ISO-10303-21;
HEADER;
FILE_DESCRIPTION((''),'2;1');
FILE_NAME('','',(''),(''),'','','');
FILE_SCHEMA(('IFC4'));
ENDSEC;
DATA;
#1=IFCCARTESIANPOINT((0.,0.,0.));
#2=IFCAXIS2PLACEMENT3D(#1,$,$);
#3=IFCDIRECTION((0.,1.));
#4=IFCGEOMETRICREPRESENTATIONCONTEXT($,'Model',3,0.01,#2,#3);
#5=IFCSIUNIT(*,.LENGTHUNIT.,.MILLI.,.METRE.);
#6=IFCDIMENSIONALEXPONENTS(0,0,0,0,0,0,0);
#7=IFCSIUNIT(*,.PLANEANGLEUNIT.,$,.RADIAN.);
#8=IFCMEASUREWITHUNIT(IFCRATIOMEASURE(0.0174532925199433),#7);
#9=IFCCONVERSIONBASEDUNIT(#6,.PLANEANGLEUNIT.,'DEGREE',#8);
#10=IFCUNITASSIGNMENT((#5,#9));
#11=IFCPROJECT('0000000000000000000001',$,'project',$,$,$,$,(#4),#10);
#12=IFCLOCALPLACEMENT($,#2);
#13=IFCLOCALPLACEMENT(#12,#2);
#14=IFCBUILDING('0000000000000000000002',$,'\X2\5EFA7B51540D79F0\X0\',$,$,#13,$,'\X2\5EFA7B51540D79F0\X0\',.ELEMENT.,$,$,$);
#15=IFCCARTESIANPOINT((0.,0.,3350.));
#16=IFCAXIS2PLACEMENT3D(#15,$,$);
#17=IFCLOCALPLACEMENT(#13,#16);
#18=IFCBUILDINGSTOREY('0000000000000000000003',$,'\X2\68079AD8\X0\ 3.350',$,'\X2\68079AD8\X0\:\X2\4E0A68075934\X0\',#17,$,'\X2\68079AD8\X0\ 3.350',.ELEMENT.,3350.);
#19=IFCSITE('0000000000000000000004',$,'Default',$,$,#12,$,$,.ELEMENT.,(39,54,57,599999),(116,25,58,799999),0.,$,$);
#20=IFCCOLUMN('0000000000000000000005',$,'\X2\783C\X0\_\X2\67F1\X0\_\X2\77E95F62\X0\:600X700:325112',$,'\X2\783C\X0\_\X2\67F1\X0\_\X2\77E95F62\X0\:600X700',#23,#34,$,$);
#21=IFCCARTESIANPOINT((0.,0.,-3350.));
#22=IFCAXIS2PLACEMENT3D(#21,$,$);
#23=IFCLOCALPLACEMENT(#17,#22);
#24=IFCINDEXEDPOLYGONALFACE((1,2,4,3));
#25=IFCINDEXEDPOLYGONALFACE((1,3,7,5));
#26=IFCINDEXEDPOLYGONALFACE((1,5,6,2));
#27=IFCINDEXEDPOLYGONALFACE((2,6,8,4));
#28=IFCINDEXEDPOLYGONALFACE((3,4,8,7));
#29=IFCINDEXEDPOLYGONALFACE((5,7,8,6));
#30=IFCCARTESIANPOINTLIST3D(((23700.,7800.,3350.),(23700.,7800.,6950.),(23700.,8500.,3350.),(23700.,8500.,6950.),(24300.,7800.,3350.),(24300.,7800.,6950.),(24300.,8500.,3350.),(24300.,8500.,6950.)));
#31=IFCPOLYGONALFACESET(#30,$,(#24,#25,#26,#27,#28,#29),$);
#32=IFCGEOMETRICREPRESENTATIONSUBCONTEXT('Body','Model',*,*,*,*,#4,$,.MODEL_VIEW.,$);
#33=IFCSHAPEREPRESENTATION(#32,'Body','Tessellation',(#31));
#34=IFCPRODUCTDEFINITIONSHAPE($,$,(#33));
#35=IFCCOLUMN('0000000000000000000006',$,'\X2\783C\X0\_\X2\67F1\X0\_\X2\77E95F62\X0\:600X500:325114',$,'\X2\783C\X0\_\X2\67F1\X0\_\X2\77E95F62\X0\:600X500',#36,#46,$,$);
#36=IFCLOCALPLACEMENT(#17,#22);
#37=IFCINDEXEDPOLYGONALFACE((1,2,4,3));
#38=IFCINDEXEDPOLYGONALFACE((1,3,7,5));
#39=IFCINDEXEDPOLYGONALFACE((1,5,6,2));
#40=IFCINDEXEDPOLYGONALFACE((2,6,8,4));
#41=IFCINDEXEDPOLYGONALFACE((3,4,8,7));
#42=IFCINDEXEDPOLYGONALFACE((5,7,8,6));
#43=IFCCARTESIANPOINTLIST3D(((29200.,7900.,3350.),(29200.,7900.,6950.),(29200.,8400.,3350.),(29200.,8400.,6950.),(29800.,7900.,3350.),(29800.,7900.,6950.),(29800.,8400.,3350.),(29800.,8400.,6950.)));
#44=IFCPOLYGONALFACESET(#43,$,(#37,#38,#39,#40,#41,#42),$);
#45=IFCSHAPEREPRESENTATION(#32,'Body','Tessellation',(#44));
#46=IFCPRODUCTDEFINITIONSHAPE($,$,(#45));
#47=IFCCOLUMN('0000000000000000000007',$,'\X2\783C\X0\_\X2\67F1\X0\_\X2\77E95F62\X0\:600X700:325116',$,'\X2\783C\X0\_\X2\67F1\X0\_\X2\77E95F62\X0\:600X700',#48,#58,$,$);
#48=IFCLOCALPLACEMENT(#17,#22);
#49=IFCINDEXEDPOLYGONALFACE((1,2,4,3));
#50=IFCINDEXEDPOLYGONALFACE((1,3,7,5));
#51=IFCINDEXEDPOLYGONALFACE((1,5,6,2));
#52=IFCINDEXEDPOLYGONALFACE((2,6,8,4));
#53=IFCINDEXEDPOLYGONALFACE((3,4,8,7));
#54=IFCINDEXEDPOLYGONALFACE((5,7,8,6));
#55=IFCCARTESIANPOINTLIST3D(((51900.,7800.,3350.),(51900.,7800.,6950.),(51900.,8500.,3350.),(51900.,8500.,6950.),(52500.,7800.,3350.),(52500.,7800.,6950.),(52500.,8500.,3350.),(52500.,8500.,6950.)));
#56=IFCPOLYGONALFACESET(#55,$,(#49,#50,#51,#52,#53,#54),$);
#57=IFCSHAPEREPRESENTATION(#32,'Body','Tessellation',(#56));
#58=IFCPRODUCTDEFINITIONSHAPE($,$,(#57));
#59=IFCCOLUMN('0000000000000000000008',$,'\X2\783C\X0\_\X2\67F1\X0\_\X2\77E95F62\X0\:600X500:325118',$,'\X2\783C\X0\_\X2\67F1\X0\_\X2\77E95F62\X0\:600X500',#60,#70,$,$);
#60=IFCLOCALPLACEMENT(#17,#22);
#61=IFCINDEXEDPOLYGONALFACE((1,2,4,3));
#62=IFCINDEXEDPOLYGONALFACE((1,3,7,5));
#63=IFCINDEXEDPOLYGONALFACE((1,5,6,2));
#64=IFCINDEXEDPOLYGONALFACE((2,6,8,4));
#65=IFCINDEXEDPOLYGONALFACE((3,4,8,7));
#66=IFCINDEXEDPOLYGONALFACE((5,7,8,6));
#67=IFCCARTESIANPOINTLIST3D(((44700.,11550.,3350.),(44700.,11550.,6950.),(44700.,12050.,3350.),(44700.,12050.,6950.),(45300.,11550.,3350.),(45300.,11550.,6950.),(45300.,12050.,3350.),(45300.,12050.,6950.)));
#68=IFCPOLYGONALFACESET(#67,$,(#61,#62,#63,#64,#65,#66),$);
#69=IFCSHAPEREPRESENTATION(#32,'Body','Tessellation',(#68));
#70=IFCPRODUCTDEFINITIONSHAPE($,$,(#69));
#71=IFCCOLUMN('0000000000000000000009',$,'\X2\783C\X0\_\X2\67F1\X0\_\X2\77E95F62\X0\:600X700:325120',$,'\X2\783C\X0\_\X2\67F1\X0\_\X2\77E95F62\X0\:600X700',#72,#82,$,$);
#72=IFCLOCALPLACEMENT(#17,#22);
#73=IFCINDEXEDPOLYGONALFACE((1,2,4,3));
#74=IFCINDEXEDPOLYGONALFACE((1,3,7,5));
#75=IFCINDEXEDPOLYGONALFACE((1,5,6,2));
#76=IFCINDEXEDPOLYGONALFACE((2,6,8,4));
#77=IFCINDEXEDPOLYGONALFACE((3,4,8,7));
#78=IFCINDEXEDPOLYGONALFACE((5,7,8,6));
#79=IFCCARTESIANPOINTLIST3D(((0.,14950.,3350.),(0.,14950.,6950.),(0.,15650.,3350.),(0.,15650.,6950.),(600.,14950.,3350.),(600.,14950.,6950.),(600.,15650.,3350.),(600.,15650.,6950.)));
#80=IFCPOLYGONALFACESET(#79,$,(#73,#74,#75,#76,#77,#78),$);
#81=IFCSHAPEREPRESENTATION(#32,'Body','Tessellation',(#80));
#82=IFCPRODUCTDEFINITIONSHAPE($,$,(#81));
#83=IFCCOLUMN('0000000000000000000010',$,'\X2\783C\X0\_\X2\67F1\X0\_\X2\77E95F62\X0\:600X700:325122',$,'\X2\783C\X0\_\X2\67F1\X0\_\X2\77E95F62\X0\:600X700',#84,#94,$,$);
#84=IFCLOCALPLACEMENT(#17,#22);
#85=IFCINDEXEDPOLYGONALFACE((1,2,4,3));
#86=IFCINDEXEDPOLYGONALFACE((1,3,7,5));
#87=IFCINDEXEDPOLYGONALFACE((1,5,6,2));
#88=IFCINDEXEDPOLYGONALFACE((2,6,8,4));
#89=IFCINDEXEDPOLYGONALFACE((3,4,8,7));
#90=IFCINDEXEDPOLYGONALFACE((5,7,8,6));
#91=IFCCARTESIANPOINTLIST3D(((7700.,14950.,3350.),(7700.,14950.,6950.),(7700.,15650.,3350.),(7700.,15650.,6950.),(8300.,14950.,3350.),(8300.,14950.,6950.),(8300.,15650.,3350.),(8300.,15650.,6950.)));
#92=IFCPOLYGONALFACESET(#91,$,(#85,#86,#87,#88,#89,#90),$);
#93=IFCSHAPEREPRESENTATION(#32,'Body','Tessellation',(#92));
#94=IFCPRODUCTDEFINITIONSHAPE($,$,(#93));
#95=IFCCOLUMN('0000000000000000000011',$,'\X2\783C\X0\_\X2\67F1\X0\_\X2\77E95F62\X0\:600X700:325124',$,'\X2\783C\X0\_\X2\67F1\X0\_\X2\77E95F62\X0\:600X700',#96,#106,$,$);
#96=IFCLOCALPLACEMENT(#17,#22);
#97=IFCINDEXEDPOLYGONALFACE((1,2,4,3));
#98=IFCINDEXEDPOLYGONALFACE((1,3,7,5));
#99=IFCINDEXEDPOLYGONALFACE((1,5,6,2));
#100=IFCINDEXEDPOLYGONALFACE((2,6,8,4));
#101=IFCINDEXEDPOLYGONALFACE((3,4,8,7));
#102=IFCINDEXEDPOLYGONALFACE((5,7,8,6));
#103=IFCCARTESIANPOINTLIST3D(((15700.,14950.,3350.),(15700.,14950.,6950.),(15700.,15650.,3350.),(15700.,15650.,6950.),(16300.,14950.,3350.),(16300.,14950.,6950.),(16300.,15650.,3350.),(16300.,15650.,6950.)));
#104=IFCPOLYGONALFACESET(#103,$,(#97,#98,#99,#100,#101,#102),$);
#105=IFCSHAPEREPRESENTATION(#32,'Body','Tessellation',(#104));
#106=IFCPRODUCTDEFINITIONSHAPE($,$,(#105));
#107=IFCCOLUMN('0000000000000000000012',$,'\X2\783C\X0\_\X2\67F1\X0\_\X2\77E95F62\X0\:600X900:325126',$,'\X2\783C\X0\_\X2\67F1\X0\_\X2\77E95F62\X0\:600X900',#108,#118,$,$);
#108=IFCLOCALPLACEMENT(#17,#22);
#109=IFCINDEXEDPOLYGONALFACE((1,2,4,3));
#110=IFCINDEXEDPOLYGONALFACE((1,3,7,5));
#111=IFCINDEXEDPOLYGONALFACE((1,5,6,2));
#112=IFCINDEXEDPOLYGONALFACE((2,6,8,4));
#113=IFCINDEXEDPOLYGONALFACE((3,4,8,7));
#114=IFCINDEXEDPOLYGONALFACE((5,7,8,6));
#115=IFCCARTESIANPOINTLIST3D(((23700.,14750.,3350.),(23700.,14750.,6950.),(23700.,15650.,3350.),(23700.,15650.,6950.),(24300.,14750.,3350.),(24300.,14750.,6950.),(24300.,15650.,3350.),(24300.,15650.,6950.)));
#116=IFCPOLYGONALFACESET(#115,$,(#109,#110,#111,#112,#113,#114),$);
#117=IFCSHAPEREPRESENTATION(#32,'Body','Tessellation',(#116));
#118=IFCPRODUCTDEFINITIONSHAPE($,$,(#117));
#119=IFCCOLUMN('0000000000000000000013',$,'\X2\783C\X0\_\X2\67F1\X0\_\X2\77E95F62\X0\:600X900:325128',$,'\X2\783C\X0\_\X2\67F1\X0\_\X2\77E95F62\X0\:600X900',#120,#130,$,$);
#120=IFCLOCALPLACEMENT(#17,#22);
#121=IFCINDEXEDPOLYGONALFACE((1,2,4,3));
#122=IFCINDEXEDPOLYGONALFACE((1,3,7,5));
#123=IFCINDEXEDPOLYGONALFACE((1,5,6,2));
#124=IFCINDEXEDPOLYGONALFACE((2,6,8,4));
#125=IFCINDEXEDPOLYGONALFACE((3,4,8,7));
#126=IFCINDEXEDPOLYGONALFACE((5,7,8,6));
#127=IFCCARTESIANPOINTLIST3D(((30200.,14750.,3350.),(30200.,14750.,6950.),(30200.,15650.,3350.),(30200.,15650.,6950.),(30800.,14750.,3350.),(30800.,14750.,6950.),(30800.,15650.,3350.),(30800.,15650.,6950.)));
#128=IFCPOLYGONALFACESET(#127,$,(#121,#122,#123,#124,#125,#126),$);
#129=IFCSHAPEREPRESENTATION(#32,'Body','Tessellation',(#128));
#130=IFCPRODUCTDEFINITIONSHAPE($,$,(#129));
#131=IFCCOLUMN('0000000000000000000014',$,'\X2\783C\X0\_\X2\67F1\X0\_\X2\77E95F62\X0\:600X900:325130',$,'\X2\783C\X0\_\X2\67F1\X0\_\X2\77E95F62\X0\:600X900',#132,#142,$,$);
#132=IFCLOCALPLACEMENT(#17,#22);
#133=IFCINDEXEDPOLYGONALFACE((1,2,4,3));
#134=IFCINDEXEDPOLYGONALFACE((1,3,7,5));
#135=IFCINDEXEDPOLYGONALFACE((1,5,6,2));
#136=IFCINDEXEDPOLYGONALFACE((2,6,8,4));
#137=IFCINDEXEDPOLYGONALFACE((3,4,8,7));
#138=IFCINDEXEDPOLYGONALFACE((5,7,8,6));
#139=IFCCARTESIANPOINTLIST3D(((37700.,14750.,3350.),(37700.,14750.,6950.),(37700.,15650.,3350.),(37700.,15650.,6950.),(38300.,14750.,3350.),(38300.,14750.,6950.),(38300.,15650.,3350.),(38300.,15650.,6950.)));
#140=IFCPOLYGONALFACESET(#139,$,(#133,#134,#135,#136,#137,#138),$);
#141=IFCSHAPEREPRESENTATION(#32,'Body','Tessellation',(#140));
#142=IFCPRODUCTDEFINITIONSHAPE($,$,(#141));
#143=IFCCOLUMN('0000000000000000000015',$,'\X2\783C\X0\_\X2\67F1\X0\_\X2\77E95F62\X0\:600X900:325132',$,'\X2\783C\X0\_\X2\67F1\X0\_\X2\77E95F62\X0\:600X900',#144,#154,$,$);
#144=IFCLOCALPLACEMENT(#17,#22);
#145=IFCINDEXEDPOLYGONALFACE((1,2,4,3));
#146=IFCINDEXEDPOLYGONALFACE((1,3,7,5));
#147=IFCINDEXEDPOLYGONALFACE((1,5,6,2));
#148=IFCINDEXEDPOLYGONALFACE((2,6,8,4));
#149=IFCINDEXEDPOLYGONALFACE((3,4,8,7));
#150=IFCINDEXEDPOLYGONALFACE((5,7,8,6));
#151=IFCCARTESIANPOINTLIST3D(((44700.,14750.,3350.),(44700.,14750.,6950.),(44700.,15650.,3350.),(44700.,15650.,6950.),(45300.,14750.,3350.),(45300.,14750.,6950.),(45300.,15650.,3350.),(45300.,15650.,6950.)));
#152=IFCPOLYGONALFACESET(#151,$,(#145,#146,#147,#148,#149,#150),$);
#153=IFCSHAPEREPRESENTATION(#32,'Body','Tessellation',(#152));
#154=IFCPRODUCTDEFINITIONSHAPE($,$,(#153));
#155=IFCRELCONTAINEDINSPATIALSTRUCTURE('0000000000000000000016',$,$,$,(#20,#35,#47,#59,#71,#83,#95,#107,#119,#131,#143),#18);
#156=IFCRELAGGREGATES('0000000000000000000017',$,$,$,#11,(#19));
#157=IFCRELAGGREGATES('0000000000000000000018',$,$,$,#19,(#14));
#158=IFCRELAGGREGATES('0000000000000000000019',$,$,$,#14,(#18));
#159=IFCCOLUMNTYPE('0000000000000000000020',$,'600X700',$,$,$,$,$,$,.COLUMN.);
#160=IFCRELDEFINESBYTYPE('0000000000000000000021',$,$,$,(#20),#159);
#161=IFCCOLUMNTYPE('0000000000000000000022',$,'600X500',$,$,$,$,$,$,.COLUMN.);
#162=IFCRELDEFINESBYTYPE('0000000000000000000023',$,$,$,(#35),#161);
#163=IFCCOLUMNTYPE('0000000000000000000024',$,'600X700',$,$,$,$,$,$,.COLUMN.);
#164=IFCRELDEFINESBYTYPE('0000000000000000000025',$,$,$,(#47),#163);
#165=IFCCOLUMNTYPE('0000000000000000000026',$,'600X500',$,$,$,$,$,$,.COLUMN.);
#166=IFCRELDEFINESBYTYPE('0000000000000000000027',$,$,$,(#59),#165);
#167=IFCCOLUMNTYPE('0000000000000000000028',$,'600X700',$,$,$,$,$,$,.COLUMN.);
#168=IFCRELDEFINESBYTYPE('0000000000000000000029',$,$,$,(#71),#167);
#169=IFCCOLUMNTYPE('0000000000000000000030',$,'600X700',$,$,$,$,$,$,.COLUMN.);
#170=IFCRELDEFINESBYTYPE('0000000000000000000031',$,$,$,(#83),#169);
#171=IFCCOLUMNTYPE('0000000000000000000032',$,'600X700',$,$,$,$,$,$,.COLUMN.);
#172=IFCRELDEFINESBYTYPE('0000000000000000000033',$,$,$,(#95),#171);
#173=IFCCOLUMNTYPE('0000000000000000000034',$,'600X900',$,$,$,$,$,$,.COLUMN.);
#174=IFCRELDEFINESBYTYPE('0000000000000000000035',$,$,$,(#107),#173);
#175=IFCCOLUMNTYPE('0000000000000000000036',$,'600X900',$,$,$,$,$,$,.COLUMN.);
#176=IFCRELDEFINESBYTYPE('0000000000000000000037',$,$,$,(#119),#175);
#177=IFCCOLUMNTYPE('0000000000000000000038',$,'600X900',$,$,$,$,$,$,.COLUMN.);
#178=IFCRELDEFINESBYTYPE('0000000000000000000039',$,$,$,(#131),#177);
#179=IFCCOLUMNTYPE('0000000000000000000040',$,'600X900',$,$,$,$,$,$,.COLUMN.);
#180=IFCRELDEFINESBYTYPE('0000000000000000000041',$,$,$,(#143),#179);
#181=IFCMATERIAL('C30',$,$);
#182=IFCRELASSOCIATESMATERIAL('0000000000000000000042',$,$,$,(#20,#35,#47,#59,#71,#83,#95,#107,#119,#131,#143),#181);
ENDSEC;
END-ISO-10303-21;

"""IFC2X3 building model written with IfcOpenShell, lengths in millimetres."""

from ifc_helpers import new_model, entity, si_unit, converted_unit, direction, frame, frame_2d, origin, origin_2d_with_axis, place, context, subcontext, project, spatial, rectangle, extrude, source, transform, mapped, material, type_object, type_shapes, element, save


model = new_model("IFC2X3")

# Units and contexts
model_context = context("Model", 3, precision=0.01, world=origin(), true_north=direction((0.0, 1.0)))
body_context = subcontext(model_context, "Body", "Model", "MODEL_VIEW")
ifc_project = project(units=[si_unit("LENGTHUNIT", "METRE", prefix="MILLI"), converted_unit("PLANEANGLEUNIT", "DEGREE", entity("IfcRatioMeasure", 0.0174532925199433), si_unit("PLANEANGLEUNIT", "RADIAN"), dimensions=[0, 0, 0, 0, 0, 0, 0])], contexts=[model_context])

# Site, building, storey
site_placement = place(None, origin())
site = spatial("IfcSite", under=ifc_project, at=site_placement, Name="Default", CompositionType="ELEMENT", RefLatitude=(39, 54, 57, 599999), RefLongitude=(116, 25, 58, 799999), RefElevation=0.0)
building_placement = place(site_placement, origin())
building = spatial("IfcBuilding", under=site, at=building_placement, Name="建筑名称", LongName="建筑名称", CompositionType="ELEMENT")
storey_placement = place(building_placement, frame((0.0, 0.0, 3350.0)))
storey = spatial("IfcBuildingStorey", under=building, at=storey_placement, Name="标高 3.350", ObjectType="标高:上标头", LongName="标高 3.350", CompositionType="ELEMENT", Elevation=3350.0)

# Columns
ifc_material = material(Name="C30")
column_type_1 = type_object("IfcColumnType", Name="600X700", PredefinedType="COLUMN")
shared_shape_1 = source(origin(), body_context, "Body", "SweptSolid", [
    extrude(rectangle(XDim=700.0, YDim=600.0, at=origin_2d_with_axis()), frame((24000.0, 8150.0, 3350.0), z_axis=(0.0, 0.0, 1.0), x_axis=(0.0, -1.0, 0.0)), (0.0, 0.0, 1.0), 3600.0),
])
type_shapes(column_type_1, [shared_shape_1])
column_1_placement = place(storey_placement, frame((0.0, 0.0, -3350.0)))
element("IfcColumn", 1, at=column_1_placement, inside=storey, type_object=column_type_1, material=ifc_material, Name="砼_柱_矩形:600X700:325112", ObjectType="砼_柱_矩形:600X700", context=body_context, shape_type="MappedRepresentation", body=[
    mapped(shared_shape_1, transform((0.0, 0.0, 0.0), scale=1.0)),
])
column_type_2 = type_object("IfcColumnType", Name="600X500", PredefinedType="COLUMN")
shared_shape_2 = source(origin(), body_context, "Body", "SweptSolid", [
    extrude(rectangle(XDim=500.0, YDim=600.0, at=frame_2d((0.0, 0.0), x_axis=(1.0, 0.0))), frame((29500.0, 8150.0, 3350.0), z_axis=(0.0, 0.0, 1.0), x_axis=(0.0, -1.0, 0.0)), (0.0, 0.0, 1.0), 3600.0),
])
type_shapes(column_type_2, [shared_shape_2])
column_2_placement = place(storey_placement, frame((0.0, 0.0, -3350.0)))
element("IfcColumn", 2, at=column_2_placement, inside=storey, type_object=column_type_2, material=ifc_material, Name="砼_柱_矩形:600X500:325114", ObjectType="砼_柱_矩形:600X500", context=body_context, shape_type="MappedRepresentation", body=[
    mapped(shared_shape_2, transform((0.0, 0.0, 0.0), scale=1.0)),
])
column_type_3 = type_object("IfcColumnType", Name="600X700", PredefinedType="COLUMN")
shared_shape_3 = source(origin(), body_context, "Body", "SweptSolid", [
    extrude(rectangle(XDim=700.0, YDim=600.0, at=origin_2d_with_axis()), frame((52200.0, 8150.0, 3350.0), z_axis=(0.0, 0.0, 1.0), x_axis=(0.0, -1.0, 0.0)), (0.0, 0.0, 1.0), 3600.0),
])
type_shapes(column_type_3, [shared_shape_3])
column_3_placement = place(storey_placement, frame((0.0, 0.0, -3350.0)))
element("IfcColumn", 3, at=column_3_placement, inside=storey, type_object=column_type_3, material=ifc_material, Name="砼_柱_矩形:600X700:325116", ObjectType="砼_柱_矩形:600X700", context=body_context, shape_type="MappedRepresentation", body=[
    mapped(shared_shape_3, transform((0.0, 0.0, 0.0), scale=1.0)),
])
column_type_4 = type_object("IfcColumnType", Name="600X500", PredefinedType="COLUMN")
shared_shape_4 = source(origin(), body_context, "Body", "SweptSolid", [
    extrude(rectangle(XDim=500.0, YDim=600.0, at=origin_2d_with_axis()), frame((45000.0, 11800.0, 3350.0), z_axis=(0.0, 0.0, 1.0), x_axis=(0.0, -1.0, 0.0)), (0.0, 0.0, 1.0), 3600.0),
])
type_shapes(column_type_4, [shared_shape_4])
column_4_placement = place(storey_placement, frame((0.0, 0.0, -3350.0)))
element("IfcColumn", 4, at=column_4_placement, inside=storey, type_object=column_type_4, material=ifc_material, Name="砼_柱_矩形:600X500:325118", ObjectType="砼_柱_矩形:600X500", context=body_context, shape_type="MappedRepresentation", body=[
    mapped(shared_shape_4, transform((0.0, 0.0, 0.0), scale=1.0)),
])
column_type_5 = type_object("IfcColumnType", Name="600X700", PredefinedType="COLUMN")
shared_shape_5 = source(origin(), body_context, "Body", "SweptSolid", [
    extrude(rectangle(XDim=700.0, YDim=600.0, at=origin_2d_with_axis()), frame((300.0, 15300.0, 3350.0), z_axis=(0.0, 0.0, 1.0), x_axis=(0.0, -1.0, 0.0)), (0.0, 0.0, 1.0), 3600.0),
])
type_shapes(column_type_5, [shared_shape_5])
column_5_placement = place(storey_placement, frame((0.0, 0.0, -3350.0)))
element("IfcColumn", 5, at=column_5_placement, inside=storey, type_object=column_type_5, material=ifc_material, Name="砼_柱_矩形:600X700:325120", ObjectType="砼_柱_矩形:600X700", context=body_context, shape_type="MappedRepresentation", body=[
    mapped(shared_shape_5, transform((0.0, 0.0, 0.0), scale=1.0)),
])
column_type_6 = type_object("IfcColumnType", Name="600X700", PredefinedType="COLUMN")
shared_shape_6 = source(origin(), body_context, "Body", "SweptSolid", [
    extrude(rectangle(XDim=700.0, YDim=600.0, at=origin_2d_with_axis()), frame((8000.0, 15300.0, 3350.0), z_axis=(0.0, 0.0, 1.0), x_axis=(0.0, -1.0, 0.0)), (0.0, 0.0, 1.0), 3600.0),
])
type_shapes(column_type_6, [shared_shape_6])
column_6_placement = place(storey_placement, frame((0.0, 0.0, -3350.0)))
element("IfcColumn", 6, at=column_6_placement, inside=storey, type_object=column_type_6, material=ifc_material, Name="砼_柱_矩形:600X700:325122", ObjectType="砼_柱_矩形:600X700", context=body_context, shape_type="MappedRepresentation", body=[
    mapped(shared_shape_6, transform((0.0, 0.0, 0.0), scale=1.0)),
])
column_type_7 = type_object("IfcColumnType", Name="600X700", PredefinedType="COLUMN")
shared_shape_7 = source(origin(), body_context, "Body", "SweptSolid", [
    extrude(rectangle(XDim=700.0, YDim=600.0, at=frame_2d((0.0, 0.0), x_axis=(1.0, 0.0))), frame((16000.0, 15300.0, 3350.0), z_axis=(0.0, 0.0, 1.0), x_axis=(0.0, -1.0, 0.0)), (0.0, 0.0, 1.0), 3600.0),
])
type_shapes(column_type_7, [shared_shape_7])
column_7_placement = place(storey_placement, frame((0.0, 0.0, -3350.0)))
element("IfcColumn", 7, at=column_7_placement, inside=storey, type_object=column_type_7, material=ifc_material, Name="砼_柱_矩形:600X700:325124", ObjectType="砼_柱_矩形:600X700", context=body_context, shape_type="MappedRepresentation", body=[
    mapped(shared_shape_7, transform((0.0, 0.0, 0.0), scale=1.0)),
])
column_type_8 = type_object("IfcColumnType", Name="600X900", PredefinedType="COLUMN")
shared_shape_8 = source(origin(), body_context, "Body", "SweptSolid", [
    extrude(rectangle(XDim=900.0, YDim=600.0, at=origin_2d_with_axis()), frame((24000.0, 15200.0, 3350.0), z_axis=(0.0, 0.0, 1.0), x_axis=(0.0, -1.0, 0.0)), (0.0, 0.0, 1.0), 3600.0),
])
type_shapes(column_type_8, [shared_shape_8])
column_8_placement = place(storey_placement, frame((0.0, 0.0, -3350.0)))
element("IfcColumn", 8, at=column_8_placement, inside=storey, type_object=column_type_8, material=ifc_material, Name="砼_柱_矩形:600X900:325126", ObjectType="砼_柱_矩形:600X900", context=body_context, shape_type="MappedRepresentation", body=[
    mapped(shared_shape_8, transform((0.0, 0.0, 0.0), scale=1.0)),
])
column_type_9 = type_object("IfcColumnType", Name="600X900", PredefinedType="COLUMN")
shared_shape_9 = source(origin(), body_context, "Body", "SweptSolid", [
    extrude(rectangle(XDim=900.0, YDim=600.0, at=origin_2d_with_axis()), frame((30500.0, 15200.0, 3350.0), z_axis=(0.0, 0.0, 1.0), x_axis=(0.0, -1.0, 0.0)), (0.0, 0.0, 1.0), 3600.0),
])
type_shapes(column_type_9, [shared_shape_9])
column_9_placement = place(storey_placement, frame((0.0, 0.0, -3350.0)))
element("IfcColumn", 9, at=column_9_placement, inside=storey, type_object=column_type_9, material=ifc_material, Name="砼_柱_矩形:600X900:325128", ObjectType="砼_柱_矩形:600X900", context=body_context, shape_type="MappedRepresentation", body=[
    mapped(shared_shape_9, transform((0.0, 0.0, 0.0), scale=1.0)),
])
column_type_10 = type_object("IfcColumnType", Name="600X900", PredefinedType="COLUMN")
shared_shape_10 = source(origin(), body_context, "Body", "SweptSolid", [
    extrude(rectangle(XDim=900.0, YDim=600.0, at=origin_2d_with_axis()), frame((38000.0, 15200.0, 3350.0), z_axis=(0.0, 0.0, 1.0), x_axis=(0.0, -1.0, 0.0)), (0.0, 0.0, 1.0), 3600.0),
])
type_shapes(column_type_10, [shared_shape_10])
column_10_placement = place(storey_placement, frame((0.0, 0.0, -3350.0)))
element("IfcColumn", 10, at=column_10_placement, inside=storey, type_object=column_type_10, material=ifc_material, Name="砼_柱_矩形:600X900:325130", ObjectType="砼_柱_矩形:600X900", context=body_context, shape_type="MappedRepresentation", body=[
    mapped(shared_shape_10, transform((0.0, 0.0, 0.0), scale=1.0)),
])
column_type_11 = type_object("IfcColumnType", Name="600X900", PredefinedType="COLUMN")
shared_shape_11 = source(origin(), body_context, "Body", "SweptSolid", [
    extrude(rectangle(XDim=900.0, YDim=600.0, at=origin_2d_with_axis()), frame((45000.0, 15200.0, 3350.0), z_axis=(0.0, 0.0, 1.0), x_axis=(0.0, -1.0, 0.0)), (0.0, 0.0, 1.0), 3600.0),
])
type_shapes(column_type_11, [shared_shape_11])
column_11_placement = place(storey_placement, frame((0.0, 0.0, -3350.0)))
element("IfcColumn", 11, at=column_11_placement, inside=storey, type_object=column_type_11, material=ifc_material, Name="砼_柱_矩形:600X900:325132", ObjectType="砼_柱_矩形:600X900", context=body_context, shape_type="MappedRepresentation", body=[
    mapped(shared_shape_11, transform((0.0, 0.0, 0.0), scale=1.0)),
])

save(model, "model.ifc")
